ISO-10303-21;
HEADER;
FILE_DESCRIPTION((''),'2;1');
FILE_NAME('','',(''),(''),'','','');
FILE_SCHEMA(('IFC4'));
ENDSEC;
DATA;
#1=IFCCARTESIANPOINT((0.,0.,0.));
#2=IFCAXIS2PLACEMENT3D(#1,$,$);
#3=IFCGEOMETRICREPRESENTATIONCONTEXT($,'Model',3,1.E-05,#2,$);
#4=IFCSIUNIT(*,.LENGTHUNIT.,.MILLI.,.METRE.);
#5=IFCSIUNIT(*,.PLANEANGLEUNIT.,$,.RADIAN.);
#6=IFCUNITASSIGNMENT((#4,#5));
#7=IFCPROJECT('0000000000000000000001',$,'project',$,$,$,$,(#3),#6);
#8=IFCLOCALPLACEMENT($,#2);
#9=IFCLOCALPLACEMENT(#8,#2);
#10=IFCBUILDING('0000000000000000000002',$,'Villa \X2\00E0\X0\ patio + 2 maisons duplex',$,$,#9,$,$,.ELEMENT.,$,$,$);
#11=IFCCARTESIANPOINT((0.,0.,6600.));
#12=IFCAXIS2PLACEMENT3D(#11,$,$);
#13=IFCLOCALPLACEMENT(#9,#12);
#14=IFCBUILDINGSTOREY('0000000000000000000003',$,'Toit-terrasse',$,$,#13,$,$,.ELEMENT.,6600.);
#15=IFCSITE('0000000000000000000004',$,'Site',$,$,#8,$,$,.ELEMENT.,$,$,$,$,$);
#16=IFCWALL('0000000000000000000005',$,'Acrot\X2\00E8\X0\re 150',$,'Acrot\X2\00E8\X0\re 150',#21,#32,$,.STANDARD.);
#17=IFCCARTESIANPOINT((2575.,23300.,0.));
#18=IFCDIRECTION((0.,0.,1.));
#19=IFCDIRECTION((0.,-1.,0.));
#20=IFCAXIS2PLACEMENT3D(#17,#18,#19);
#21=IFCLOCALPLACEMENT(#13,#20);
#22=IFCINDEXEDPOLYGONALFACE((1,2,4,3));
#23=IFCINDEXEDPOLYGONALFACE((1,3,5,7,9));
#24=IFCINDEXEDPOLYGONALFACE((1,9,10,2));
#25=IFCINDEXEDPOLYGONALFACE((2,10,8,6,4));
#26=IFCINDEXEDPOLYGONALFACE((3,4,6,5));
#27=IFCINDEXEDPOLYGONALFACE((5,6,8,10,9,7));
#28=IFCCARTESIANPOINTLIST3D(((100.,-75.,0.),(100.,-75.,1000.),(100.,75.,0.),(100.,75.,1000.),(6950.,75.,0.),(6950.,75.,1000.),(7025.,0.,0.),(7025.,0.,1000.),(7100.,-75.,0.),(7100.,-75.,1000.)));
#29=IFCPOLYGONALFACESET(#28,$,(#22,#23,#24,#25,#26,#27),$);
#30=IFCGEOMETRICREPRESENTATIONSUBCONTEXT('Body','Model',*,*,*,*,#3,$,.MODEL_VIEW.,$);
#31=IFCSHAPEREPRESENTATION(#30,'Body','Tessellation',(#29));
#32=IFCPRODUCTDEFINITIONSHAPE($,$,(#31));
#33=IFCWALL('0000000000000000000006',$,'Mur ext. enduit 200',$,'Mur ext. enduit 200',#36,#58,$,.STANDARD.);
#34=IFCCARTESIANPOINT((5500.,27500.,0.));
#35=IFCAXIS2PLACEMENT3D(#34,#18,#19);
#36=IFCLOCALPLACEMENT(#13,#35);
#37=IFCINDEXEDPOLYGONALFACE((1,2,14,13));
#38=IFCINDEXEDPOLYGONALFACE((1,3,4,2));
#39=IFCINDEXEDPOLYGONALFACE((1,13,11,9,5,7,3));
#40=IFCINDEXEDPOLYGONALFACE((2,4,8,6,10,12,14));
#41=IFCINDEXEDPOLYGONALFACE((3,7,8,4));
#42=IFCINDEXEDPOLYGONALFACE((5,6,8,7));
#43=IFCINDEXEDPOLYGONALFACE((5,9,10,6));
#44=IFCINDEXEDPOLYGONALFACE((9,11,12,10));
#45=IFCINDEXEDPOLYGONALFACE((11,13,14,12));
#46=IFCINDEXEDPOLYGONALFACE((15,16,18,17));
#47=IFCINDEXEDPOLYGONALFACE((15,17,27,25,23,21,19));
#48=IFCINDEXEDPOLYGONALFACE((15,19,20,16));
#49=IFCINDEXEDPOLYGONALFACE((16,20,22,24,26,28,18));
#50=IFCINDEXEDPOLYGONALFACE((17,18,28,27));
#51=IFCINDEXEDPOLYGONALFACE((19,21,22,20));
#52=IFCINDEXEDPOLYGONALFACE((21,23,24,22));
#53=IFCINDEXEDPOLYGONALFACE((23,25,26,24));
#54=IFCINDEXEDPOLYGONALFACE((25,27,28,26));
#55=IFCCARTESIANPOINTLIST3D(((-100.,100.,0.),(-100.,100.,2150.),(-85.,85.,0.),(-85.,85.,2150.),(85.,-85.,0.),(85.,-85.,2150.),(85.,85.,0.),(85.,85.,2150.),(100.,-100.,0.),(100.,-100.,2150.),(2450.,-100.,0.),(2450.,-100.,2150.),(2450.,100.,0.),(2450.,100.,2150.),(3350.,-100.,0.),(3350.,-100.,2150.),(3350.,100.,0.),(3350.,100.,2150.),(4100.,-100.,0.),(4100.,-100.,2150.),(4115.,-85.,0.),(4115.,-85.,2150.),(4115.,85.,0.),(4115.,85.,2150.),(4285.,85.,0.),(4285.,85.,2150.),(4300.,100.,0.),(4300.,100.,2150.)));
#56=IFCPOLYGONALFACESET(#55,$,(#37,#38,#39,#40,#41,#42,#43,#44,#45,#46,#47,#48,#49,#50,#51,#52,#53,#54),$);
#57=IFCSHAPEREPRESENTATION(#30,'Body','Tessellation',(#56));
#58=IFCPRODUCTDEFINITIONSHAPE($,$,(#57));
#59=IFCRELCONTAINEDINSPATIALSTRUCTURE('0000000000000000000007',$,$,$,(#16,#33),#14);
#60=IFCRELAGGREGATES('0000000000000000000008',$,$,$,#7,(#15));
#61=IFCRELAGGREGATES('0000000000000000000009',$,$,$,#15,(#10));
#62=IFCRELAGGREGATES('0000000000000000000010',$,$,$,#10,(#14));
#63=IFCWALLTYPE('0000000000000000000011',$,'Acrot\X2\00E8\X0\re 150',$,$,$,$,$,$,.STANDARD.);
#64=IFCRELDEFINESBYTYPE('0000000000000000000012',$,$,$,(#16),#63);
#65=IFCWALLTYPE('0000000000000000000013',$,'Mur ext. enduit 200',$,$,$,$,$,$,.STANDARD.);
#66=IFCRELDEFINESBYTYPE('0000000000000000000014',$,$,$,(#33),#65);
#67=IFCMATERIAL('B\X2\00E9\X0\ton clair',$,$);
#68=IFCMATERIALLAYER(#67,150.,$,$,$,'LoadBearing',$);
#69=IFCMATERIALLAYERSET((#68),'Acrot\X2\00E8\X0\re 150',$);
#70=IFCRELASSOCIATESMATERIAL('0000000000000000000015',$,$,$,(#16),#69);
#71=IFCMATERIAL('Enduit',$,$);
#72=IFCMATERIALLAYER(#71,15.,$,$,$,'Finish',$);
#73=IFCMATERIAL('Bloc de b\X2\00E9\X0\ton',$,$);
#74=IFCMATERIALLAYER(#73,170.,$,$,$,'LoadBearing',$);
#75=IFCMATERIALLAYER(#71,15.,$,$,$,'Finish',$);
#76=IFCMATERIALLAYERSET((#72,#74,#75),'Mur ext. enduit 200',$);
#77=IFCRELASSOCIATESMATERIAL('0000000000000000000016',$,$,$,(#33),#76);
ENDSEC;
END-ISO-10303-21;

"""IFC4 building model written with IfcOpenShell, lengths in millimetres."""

from ifc_helpers import new_model, si_unit, frame, frame_2d, origin, place, context, subcontext, project, spatial, polyline, rectangle, outline, extrude, material, layer, layer_set, layer_usage, type_object, element, save


model = new_model("IFC4")

# Units and contexts
model_context = context("Model", 3, precision=1e-05, world=origin())
body_context = subcontext(model_context, "Body", "Model", "MODEL_VIEW")
ifc_project = project(units=[si_unit("LENGTHUNIT", "METRE", prefix="MILLI"), si_unit("PLANEANGLEUNIT", "RADIAN")], contexts=[model_context])

# Site, building, storey
site_placement = place(None, origin())
site = spatial("IfcSite", under=ifc_project, at=site_placement, Name="Site", CompositionType="ELEMENT")
building_placement = place(site_placement, origin())
building = spatial("IfcBuilding", under=site, at=building_placement, Name="Villa à patio + 2 maisons duplex", CompositionType="ELEMENT")
storey_placement = place(building_placement, frame((0.0, 0.0, 6600.0)))
storey = spatial("IfcBuildingStorey", under=building, at=storey_placement, Name="Toit-terrasse", CompositionType="ELEMENT", Elevation=6600.0)

# Wall
ifc_material_1 = material(Name="Béton clair")
ifc_layer_1 = layer(ifc_material_1, 150.0, Category="LoadBearing")
ifc_layer_set_1 = layer_set([ifc_layer_1], Name="Acrotère 150")
ifc_layer_usage_1 = layer_usage(ifc_layer_set_1, "AXIS2", "NEGATIVE", 75.0)
wall_type_1 = type_object("IfcWallType", Name="Acrotère 150", PredefinedType="STANDARD")
wall_1_placement = place(storey_placement, frame((2575.0, 23300.0, 0.0), z_axis=(0.0, 0.0, 1.0), x_axis=(0.0, -1.0, 0.0)))
element("IfcWall", 1, at=wall_1_placement, inside=storey, type_object=wall_type_1, material=ifc_layer_usage_1, Name="Acrotère 150", ObjectType="Acrotère 150", PredefinedType="STANDARD", context=body_context, shape_type="SweptSolid", body=[
    extrude(outline(polyline([(100.0, -75.0), (100.0, 75.0), (6950.0, 75.0), (7025.0, 0.0), (7100.0, -75.0), (100.0, -75.0)])), origin(), (0.0, 0.0, 1.0), 1000.0),
])
ifc_material_2 = material(Name="Enduit")
ifc_layer_2 = layer(ifc_material_2, 15.0, Category="Finish")
ifc_material_3 = material(Name="Bloc de béton")
ifc_layer_3 = layer(ifc_material_3, 170.0, Category="LoadBearing")
ifc_layer_4 = layer(ifc_material_2, 15.0, Category="Finish")
ifc_layer_set_2 = layer_set([ifc_layer_2, ifc_layer_3, ifc_layer_4], Name="Mur ext. enduit 200")
ifc_layer_usage_2 = layer_usage(ifc_layer_set_2, "AXIS2", "NEGATIVE", 100.0)
wall_type_2 = type_object("IfcWallType", Name="Mur ext. enduit 200", PredefinedType="STANDARD")

# Wall, opening
wall_2_placement = place(storey_placement, frame((5500.0, 27500.0, 0.0), z_axis=(0.0, 0.0, 1.0), x_axis=(0.0, -1.0, 0.0)))
wall_2 = element("IfcWall", 2, at=wall_2_placement, inside=storey, type_object=wall_type_2, material=ifc_layer_usage_2, Name="Mur ext. enduit 200", ObjectType="Mur ext. enduit 200", PredefinedType="STANDARD", context=body_context, shape_type="SweptSolid", body=[
    extrude(outline(polyline([(100.0, -100.0), (85.0, -85.0), (85.0, 85.0), (-85.0, 85.0), (-100.0, 100.0), (4300.0, 100.0), (4285.0, 85.0), (4115.0, 85.0), (4115.0, -85.0), (4100.0, -100.0), (100.0, -100.0)])), origin(), (0.0, 0.0, 1.0), 2150.0),
])
opening_1_placement = place(wall_2_placement, frame((2450.0, 0.0, 0.0), z_axis=(0.0, 0.0, 1.0), x_axis=(1.0, 0.0, 0.0)))
element("IfcOpeningElement", 3, at=opening_1_placement, cuts=wall_2, PredefinedType="OPENING", context=body_context, shape_type="SweptSolid", body=[
    extrude(rectangle(XDim=900.0, YDim=220.0, at=frame_2d((450.0, 0.0))), origin(), (0.0, 0.0, 1.0), 2400.0),
])

save(model, "model.ifc")
